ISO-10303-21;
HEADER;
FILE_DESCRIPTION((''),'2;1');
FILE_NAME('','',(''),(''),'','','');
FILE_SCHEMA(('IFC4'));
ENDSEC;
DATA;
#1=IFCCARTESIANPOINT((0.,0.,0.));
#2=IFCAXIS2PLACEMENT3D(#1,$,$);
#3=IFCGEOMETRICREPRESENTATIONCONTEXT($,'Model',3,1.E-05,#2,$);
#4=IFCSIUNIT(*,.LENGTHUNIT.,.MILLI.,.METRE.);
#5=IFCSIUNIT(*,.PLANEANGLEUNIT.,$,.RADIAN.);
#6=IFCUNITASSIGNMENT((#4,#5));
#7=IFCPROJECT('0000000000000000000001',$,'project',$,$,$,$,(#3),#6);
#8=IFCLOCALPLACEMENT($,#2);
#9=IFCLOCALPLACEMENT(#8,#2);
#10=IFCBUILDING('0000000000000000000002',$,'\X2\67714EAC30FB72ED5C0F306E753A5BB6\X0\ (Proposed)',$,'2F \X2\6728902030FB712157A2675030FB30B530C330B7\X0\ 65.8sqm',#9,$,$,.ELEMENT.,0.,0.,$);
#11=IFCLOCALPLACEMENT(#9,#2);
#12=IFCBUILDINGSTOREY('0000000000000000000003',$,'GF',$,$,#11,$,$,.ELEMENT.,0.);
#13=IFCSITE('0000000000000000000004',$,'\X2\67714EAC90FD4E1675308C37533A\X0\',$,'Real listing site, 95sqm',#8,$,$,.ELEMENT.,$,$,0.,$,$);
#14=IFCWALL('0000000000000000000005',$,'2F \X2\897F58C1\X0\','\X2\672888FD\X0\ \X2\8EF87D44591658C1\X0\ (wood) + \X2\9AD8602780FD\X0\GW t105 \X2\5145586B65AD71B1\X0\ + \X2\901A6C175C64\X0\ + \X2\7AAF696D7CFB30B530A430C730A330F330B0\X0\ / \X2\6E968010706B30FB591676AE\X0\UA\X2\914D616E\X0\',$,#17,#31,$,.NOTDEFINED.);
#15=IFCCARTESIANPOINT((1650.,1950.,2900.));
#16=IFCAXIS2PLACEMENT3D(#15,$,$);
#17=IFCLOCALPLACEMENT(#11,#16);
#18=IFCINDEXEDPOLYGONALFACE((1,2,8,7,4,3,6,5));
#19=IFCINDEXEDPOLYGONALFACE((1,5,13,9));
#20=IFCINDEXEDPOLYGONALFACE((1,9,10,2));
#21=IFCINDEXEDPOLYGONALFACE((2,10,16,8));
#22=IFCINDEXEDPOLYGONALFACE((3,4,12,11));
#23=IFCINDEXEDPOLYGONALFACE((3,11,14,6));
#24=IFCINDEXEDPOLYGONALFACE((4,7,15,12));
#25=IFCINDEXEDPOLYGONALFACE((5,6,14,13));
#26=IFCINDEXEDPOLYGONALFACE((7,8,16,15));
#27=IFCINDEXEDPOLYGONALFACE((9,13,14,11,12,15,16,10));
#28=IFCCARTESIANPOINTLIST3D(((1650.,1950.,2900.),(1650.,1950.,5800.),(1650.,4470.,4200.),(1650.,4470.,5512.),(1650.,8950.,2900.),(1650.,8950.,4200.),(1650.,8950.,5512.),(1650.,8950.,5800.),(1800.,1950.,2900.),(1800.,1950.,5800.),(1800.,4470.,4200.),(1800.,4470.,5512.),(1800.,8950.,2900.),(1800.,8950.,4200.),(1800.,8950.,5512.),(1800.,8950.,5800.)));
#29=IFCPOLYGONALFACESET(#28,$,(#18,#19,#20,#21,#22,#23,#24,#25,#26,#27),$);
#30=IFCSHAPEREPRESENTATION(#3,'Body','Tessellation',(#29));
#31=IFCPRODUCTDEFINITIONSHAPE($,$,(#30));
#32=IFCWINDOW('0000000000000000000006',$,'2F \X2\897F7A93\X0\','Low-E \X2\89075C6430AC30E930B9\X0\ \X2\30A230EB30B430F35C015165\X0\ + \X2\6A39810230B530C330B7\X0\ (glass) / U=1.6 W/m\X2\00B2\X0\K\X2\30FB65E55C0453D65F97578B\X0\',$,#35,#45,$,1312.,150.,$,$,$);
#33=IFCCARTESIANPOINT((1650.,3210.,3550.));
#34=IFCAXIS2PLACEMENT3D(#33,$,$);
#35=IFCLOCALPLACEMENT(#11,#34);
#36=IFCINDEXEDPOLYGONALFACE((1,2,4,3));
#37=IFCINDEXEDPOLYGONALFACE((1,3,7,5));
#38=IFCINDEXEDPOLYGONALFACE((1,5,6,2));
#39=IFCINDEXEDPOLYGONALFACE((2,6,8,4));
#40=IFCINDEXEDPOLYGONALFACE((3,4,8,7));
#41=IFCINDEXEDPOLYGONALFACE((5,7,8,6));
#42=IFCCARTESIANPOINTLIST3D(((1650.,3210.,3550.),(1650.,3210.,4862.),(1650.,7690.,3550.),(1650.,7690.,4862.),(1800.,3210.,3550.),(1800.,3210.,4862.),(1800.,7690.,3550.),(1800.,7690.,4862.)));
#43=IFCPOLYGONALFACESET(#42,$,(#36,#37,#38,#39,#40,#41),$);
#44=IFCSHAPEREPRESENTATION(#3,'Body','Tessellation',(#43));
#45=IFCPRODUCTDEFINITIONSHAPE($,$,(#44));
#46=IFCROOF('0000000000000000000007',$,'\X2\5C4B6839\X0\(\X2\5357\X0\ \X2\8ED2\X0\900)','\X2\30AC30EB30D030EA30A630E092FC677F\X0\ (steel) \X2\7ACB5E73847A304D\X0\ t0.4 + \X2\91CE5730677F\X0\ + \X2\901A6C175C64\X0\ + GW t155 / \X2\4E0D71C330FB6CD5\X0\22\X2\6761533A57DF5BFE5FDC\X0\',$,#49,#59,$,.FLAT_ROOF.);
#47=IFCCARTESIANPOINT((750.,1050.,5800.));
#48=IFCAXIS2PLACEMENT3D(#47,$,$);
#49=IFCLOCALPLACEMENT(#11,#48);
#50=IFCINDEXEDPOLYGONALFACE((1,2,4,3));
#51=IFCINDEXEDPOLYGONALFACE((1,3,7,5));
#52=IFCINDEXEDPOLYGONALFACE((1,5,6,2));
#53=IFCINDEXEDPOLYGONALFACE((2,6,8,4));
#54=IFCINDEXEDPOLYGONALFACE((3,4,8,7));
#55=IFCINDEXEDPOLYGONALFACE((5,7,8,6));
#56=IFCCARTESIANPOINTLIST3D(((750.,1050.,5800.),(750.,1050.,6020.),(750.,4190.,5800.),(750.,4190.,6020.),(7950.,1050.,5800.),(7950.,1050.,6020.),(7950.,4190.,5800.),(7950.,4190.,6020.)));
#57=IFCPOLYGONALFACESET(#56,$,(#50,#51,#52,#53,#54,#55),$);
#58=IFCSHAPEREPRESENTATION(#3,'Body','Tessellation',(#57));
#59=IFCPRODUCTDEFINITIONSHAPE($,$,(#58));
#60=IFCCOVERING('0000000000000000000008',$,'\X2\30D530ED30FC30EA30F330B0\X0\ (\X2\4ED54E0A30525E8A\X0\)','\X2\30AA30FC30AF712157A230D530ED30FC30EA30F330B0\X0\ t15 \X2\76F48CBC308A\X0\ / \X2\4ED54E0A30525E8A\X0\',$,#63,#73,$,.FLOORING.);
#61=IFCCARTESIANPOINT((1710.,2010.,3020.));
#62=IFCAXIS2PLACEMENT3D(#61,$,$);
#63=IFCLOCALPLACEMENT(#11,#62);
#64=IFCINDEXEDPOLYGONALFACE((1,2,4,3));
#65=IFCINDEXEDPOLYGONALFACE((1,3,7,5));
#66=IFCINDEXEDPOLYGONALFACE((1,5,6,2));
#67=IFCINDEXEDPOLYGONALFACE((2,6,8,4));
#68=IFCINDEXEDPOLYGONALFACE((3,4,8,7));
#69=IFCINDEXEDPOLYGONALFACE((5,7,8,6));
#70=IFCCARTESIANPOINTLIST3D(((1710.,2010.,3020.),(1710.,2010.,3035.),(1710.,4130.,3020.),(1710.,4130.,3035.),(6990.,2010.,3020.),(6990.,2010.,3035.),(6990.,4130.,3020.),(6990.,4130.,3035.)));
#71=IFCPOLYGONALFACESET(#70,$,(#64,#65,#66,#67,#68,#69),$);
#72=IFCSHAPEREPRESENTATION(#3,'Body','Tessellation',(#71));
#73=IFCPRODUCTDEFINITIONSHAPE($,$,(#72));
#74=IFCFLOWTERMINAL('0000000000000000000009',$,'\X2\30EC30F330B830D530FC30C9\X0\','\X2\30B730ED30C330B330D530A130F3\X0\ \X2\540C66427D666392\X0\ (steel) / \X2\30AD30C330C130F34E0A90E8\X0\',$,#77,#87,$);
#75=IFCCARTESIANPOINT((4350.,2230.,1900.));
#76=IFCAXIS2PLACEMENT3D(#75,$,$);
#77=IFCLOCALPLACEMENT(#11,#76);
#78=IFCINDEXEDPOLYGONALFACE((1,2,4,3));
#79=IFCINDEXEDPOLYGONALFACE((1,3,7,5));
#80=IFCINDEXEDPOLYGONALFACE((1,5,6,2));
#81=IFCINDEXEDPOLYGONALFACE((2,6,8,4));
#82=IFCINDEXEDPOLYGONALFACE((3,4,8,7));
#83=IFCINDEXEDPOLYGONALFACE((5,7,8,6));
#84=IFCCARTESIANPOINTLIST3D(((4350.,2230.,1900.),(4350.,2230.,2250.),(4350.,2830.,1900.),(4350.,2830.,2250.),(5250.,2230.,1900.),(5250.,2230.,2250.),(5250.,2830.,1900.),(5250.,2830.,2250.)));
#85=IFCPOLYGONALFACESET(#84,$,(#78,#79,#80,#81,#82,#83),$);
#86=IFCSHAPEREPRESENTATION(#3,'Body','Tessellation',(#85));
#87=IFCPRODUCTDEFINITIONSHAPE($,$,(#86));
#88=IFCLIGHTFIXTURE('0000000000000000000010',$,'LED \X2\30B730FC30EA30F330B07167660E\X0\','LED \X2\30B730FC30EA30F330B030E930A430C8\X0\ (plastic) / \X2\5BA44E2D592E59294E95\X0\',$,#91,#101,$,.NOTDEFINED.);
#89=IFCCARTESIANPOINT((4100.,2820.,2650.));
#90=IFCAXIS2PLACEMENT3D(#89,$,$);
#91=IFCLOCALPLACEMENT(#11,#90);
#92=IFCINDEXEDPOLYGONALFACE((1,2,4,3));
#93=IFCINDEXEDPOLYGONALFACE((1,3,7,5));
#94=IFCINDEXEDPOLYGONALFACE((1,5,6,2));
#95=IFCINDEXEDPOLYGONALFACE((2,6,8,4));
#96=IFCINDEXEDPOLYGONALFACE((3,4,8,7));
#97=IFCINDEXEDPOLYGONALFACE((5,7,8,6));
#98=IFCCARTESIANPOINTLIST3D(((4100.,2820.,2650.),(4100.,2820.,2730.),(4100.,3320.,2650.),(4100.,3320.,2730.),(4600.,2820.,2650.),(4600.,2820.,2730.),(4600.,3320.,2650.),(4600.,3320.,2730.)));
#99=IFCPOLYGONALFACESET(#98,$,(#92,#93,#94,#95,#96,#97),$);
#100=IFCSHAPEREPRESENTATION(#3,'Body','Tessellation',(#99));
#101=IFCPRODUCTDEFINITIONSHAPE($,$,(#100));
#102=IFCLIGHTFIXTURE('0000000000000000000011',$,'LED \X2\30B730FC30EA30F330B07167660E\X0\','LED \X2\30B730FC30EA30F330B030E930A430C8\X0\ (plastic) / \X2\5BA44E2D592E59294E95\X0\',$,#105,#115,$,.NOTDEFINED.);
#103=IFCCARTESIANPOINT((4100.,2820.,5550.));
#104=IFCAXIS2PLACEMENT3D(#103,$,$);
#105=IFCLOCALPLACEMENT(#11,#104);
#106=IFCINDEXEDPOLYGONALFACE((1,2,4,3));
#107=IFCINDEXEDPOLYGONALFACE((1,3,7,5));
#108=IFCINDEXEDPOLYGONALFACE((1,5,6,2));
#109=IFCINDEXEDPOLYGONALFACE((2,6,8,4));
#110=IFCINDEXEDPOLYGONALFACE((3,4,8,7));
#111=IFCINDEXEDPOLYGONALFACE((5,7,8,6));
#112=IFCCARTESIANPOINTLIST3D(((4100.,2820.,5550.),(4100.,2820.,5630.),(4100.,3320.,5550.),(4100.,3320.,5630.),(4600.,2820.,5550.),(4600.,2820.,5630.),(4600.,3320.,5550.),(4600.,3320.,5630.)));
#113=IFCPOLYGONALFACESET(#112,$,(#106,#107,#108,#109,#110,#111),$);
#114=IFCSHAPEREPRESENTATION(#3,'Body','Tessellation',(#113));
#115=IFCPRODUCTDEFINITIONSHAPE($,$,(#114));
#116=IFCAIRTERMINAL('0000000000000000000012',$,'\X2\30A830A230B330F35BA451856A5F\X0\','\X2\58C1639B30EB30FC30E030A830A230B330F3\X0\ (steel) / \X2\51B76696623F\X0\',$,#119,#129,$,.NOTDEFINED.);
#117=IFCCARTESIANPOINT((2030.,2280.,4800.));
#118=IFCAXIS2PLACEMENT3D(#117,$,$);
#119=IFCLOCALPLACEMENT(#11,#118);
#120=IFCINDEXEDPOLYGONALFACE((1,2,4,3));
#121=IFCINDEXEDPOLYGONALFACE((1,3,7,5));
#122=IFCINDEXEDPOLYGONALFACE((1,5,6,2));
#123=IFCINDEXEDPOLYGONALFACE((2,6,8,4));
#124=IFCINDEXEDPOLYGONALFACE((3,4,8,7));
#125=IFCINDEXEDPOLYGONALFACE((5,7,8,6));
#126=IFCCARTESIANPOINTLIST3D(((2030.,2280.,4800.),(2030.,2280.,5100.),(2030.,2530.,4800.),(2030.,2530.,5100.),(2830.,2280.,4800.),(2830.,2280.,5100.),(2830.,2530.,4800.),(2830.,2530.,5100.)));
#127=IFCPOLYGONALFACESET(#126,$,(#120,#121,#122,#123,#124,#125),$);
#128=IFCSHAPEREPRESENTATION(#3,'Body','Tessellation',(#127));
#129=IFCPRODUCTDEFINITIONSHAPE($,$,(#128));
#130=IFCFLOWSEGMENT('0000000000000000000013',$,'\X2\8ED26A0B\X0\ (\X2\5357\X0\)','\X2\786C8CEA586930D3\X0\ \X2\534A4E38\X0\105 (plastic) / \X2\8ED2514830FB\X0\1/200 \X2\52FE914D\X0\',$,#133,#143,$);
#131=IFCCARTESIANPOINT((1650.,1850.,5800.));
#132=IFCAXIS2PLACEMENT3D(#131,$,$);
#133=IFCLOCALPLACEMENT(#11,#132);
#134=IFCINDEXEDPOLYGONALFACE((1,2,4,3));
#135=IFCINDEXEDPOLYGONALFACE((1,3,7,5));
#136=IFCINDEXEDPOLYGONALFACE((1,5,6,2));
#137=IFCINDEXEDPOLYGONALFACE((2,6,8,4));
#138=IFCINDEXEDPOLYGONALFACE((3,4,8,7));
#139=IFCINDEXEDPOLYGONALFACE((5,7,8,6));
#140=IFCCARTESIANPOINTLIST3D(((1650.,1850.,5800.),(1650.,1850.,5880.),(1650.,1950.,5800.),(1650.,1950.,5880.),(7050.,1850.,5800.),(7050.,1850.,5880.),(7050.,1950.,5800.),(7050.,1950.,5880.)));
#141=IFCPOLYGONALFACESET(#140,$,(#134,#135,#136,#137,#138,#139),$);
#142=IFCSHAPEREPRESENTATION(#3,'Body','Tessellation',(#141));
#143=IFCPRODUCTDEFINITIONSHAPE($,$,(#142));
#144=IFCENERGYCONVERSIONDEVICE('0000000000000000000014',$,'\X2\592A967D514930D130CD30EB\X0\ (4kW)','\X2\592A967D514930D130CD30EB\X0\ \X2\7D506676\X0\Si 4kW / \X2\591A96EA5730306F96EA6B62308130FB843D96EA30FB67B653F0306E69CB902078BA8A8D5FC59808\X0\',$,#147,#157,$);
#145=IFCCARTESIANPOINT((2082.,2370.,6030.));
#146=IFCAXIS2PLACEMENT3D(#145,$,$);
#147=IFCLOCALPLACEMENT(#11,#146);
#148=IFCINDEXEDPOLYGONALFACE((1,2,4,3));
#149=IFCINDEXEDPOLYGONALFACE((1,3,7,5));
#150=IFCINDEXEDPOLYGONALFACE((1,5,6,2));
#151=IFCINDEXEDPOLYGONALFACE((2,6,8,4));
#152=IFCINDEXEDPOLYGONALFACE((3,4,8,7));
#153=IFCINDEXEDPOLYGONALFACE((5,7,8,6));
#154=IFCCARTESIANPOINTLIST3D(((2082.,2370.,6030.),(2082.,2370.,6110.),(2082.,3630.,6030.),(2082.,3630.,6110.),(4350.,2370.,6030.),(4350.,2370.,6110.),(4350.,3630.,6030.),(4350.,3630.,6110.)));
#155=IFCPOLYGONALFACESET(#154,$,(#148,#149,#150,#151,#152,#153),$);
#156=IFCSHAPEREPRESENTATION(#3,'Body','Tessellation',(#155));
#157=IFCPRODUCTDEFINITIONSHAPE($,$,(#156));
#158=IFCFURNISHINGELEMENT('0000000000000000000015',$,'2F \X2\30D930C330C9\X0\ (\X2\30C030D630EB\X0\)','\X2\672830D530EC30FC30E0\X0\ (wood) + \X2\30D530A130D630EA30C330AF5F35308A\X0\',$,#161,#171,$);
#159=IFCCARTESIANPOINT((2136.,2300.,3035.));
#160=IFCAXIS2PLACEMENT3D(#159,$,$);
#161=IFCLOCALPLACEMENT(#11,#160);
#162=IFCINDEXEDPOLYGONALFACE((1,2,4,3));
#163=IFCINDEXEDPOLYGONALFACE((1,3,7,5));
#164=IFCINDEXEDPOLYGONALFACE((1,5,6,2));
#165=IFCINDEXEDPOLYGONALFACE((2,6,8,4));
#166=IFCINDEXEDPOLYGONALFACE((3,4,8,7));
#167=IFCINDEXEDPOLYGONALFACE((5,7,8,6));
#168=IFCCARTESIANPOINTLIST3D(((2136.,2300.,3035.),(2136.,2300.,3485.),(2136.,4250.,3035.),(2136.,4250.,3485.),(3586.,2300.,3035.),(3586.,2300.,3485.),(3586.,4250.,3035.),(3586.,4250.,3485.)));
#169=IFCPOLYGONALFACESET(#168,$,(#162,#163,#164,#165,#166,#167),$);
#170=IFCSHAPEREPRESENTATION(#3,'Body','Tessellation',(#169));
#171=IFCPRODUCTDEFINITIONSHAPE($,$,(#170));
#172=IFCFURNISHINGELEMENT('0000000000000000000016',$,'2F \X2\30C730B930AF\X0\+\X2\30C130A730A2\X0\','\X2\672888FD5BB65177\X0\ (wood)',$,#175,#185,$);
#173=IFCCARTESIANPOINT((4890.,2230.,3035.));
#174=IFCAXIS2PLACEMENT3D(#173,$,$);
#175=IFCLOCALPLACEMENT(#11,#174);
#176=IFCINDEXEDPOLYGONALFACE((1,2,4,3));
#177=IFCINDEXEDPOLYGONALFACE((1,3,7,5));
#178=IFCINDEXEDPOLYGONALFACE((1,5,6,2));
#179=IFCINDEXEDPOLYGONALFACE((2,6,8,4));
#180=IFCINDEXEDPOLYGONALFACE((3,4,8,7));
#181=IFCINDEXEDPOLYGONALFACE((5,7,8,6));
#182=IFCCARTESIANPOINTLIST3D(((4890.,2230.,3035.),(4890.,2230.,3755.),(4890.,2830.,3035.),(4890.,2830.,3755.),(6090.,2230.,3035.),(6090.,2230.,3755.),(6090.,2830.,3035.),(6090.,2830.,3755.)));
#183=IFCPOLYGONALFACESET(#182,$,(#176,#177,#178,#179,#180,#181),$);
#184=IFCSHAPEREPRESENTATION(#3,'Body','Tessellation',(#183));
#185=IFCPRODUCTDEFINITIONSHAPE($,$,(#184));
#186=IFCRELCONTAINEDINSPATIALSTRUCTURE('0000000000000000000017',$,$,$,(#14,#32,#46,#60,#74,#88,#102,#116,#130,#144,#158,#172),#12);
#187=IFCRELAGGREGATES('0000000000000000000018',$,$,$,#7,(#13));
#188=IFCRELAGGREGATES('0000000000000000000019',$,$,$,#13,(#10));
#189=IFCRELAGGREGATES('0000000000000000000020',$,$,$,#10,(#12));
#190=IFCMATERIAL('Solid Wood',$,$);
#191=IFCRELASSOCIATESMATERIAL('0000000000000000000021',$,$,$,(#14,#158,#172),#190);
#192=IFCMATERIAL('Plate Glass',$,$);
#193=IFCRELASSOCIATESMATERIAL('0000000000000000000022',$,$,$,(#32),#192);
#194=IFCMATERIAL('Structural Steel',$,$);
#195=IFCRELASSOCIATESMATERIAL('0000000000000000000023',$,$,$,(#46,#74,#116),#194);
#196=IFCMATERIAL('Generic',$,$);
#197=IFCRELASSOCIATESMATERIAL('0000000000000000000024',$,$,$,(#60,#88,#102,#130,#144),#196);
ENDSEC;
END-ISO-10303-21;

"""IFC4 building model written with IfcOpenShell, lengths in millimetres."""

from ifc_helpers import new_model, si_unit, frame, frame_2d, origin, place, context, project, spatial, rectangle, extrude, material, element, fill, save


model = new_model("IFC4")

# Units and contexts
model_context = context("Model", 3, precision=1e-05, world=origin())
ifc_project = project(units=[si_unit("LENGTHUNIT", "METRE", prefix="MILLI"), si_unit("PLANEANGLEUNIT", "RADIAN")], contexts=[model_context])

# Site, building, storey
site_placement = place(None, origin())
site = spatial("IfcSite", under=ifc_project, at=site_placement, Name="東京都世田谷区", ObjectType="Real listing site, 95sqm", CompositionType="ELEMENT", RefElevation=0.0)
building_placement = place(site_placement, origin())
building = spatial("IfcBuilding", under=site, at=building_placement, Name="東京・狭小の町家 (Proposed)", ObjectType="2F 木造・無垢材・サッシ 65.8sqm", CompositionType="ELEMENT", ElevationOfRefHeight=0.0, ElevationOfTerrain=0.0)
storey_placement = place(building_placement, origin())
storey = spatial("IfcBuildingStorey", under=building, at=storey_placement, Name="GF", CompositionType="ELEMENT", Elevation=0.0)

# Shared definitions
ifc_material_1 = material(Name="Solid Wood")

# Wall, opening, window
ifc_material_2 = material(Name="Plate Glass")
wall_1_placement = place(storey_placement, frame((1650.0, 1950.0, 2900.0)))
wall_1 = element("IfcWall", 1, at=wall_1_placement, inside=storey, material=ifc_material_1, Name="2F 西壁", Description="木製 軸組外壁 (wood) + 高性能GW t105 充填断熱 + 通気層 + 窯業系サイディング / 準耐火・外皮UA配慮", PredefinedType="NOTDEFINED", context=model_context, shape_type="SweptSolid", body=[
    extrude(rectangle(XDim=150.0, YDim=7000.0, at=frame_2d((75.0, 3500.0))), frame((1650.0, 1950.0, 2900.0)), (0.0, 0.0, 1.0), 2900.0),
])
opening_1_placement = place(storey_placement, frame((1650.0, 3210.0, 3550.0)))
opening_1 = element("IfcOpeningElement", 2, at=opening_1_placement, cuts=wall_1, PredefinedType="NOTDEFINED", context=model_context, shape_type="SweptSolid", body=[
    extrude(rectangle(XDim=150.0, YDim=4480.0, at=frame_2d((75.0, 2240.0))), frame((1650.0, 3210.0, 3550.0)), (0.0, 0.0, 1.0), 1312.0),
])
window_1_placement = place(storey_placement, frame((1650.0, 3210.0, 3550.0)))
window_1 = element("IfcWindow", 3, at=window_1_placement, inside=storey, material=ifc_material_2, Name="2F 西窓", Description="Low-E 複層ガラス アルゴン封入 + 樹脂サッシ (glass) / U=1.6 W/m²K・日射取得型", OverallHeight=1312.0, OverallWidth=150.0, context=model_context, shape_type="SweptSolid", body=[
    extrude(rectangle(XDim=150.0, YDim=4480.0, at=frame_2d((75.0, 2240.0))), frame((1650.0, 3210.0, 3550.0)), (0.0, 0.0, 1.0), 1312.0),
])
fill(opening_1, window_1)

# Roof
ifc_material_3 = material(Name="Structural Steel")
for number, where, name in (
    (4, (750.0, 1050.0, 5800.0), "屋根(南 軒900)"),
):
    element("IfcRoof", number, at=place(storey_placement, frame(where)), inside=storey, material=ifc_material_3, Name=name, Description="ガルバリウム鋼板 (steel) 立平葺き t0.4 + 野地板 + 通気層 + GW t155 / 不燃・法22条区域対応", PredefinedType="FLAT_ROOF", context=model_context, shape_type="SweptSolid", body=[
        extrude(rectangle(XDim=7200.0, YDim=3140.0, at=frame_2d((3600.0, 1570.0))), frame((750.0, 1050.0, 5800.0)), (0.0, 0.0, 1.0), 220.0),
    ])

# Covering
ifc_material_4 = material(Name="Generic")
covering_placement = place(storey_placement, frame((1710.0, 2010.0, 3020.0)))
element("IfcCovering", 5, at=covering_placement, inside=storey, material=ifc_material_4, Name="フローリング (仕上げ床)", Description="オーク無垢フローリング t15 直貼り / 仕上げ床", PredefinedType="FLOORING", context=model_context, shape_type="SweptSolid", body=[
    extrude(rectangle(XDim=5280.0, YDim=2120.0, at=frame_2d((2640.0, 1060.0))), frame((1710.0, 2010.0, 3020.0)), (0.0, 0.0, 1.0), 15.0),
])

# Flow terminal
flow_terminal_placement = place(storey_placement, frame((4350.0, 2230.0, 1900.0)))
element("IfcFlowTerminal", 6, at=flow_terminal_placement, inside=storey, material=ifc_material_3, Name="レンジフード", Description="シロッコファン 同時給排 (steel) / キッチン上部", context=model_context, shape_type="SweptSolid", body=[
    extrude(rectangle(XDim=900.0, YDim=600.0, at=frame_2d((450.0, 300.0))), frame((4350.0, 2230.0, 1900.0)), (0.0, 0.0, 1.0), 350.0),
])

# Light fixtures
light_fixture_1_placement = place(storey_placement, frame((4100.0, 2820.0, 2650.0)))
element("IfcLightFixture", 7, at=light_fixture_1_placement, inside=storey, material=ifc_material_4, Name="LED シーリング照明", Description="LED シーリングライト (plastic) / 室中央天井", PredefinedType="NOTDEFINED", context=model_context, shape_type="SweptSolid", body=[
    extrude(rectangle(XDim=500.0, YDim=500.0, at=frame_2d((250.0, 250.0))), frame((4100.0, 2820.0, 2650.0)), (0.0, 0.0, 1.0), 80.0),
])
light_fixture_2_placement = place(storey_placement, frame((4100.0, 2820.0, 5550.0)))
element("IfcLightFixture", 8, at=light_fixture_2_placement, inside=storey, material=ifc_material_4, Name="LED シーリング照明", Description="LED シーリングライト (plastic) / 室中央天井", PredefinedType="NOTDEFINED", context=model_context, shape_type="SweptSolid", body=[
    extrude(rectangle(XDim=500.0, YDim=500.0, at=frame_2d((250.0, 250.0))), frame((4100.0, 2820.0, 5550.0)), (0.0, 0.0, 1.0), 80.0),
])

# Air terminal
air_terminal_placement = place(storey_placement, frame((2030.0, 2280.0, 4800.0)))
element("IfcAirTerminal", 9, at=air_terminal_placement, inside=storey, material=ifc_material_3, Name="エアコン室内機", Description="壁掛ルームエアコン (steel) / 冷暖房", PredefinedType="NOTDEFINED", context=model_context, shape_type="SweptSolid", body=[
    extrude(rectangle(XDim=800.0, YDim=250.0, at=frame_2d((400.0, 125.0))), frame((2030.0, 2280.0, 4800.0)), (0.0, 0.0, 1.0), 300.0),
])

# Flow segment
flow_segment_placement = place(storey_placement, frame((1650.0, 1850.0, 5800.0)))
element("IfcFlowSegment", 10, at=flow_segment_placement, inside=storey, material=ifc_material_4, Name="軒樋 (南)", Description="硬質塩ビ 半丸105 (plastic) / 軒先・1/200 勾配", context=model_context, shape_type="SweptSolid", body=[
    extrude(rectangle(XDim=5400.0, YDim=100.0, at=frame_2d((2700.0, 50.0))), frame((1650.0, 1850.0, 5800.0)), (0.0, 0.0, 1.0), 80.0),
])

# Energy conversion device
energy_conversion_device_placement = place(storey_placement, frame((2082.0, 2370.0, 6030.0)))
element("IfcEnergyConversionDevice", 11, at=energy_conversion_device_placement, inside=storey, material=ifc_material_4, Name="太陽光パネル (4kW)", Description="太陽光パネル 結晶Si 4kW / 多雪地は雪止め・落雪・架台の構造確認必須", context=model_context, shape_type="SweptSolid", body=[
    extrude(rectangle(XDim=2268.0, YDim=1260.0, at=frame_2d((1134.0, 630.0))), frame((2082.0, 2370.0, 6030.0)), (0.0, 0.0, 1.0), 80.0),
])

# Furnishing elements
furnishing_1_placement = place(storey_placement, frame((2136.0, 2300.0, 3035.0)))
element("IfcFurnishingElement", 12, at=furnishing_1_placement, inside=storey, material=ifc_material_1, Name="2F ベッド (ダブル)", Description="木フレーム (wood) + ファブリック張り", context=model_context, shape_type="SweptSolid", body=[
    extrude(rectangle(XDim=1450.0, YDim=1950.0, at=frame_2d((725.0, 975.0))), frame((2136.0, 2300.0, 3035.0)), (0.0, 0.0, 1.0), 450.0),
])
furnishing_2_placement = place(storey_placement, frame((4890.0, 2230.0, 3035.0)))
element("IfcFurnishingElement", 13, at=furnishing_2_placement, inside=storey, material=ifc_material_1, Name="2F デスク+チェア", Description="木製家具 (wood)", context=model_context, shape_type="SweptSolid", body=[
    extrude(rectangle(XDim=1200.0, YDim=600.0, at=frame_2d((600.0, 300.0))), frame((4890.0, 2230.0, 3035.0)), (0.0, 0.0, 1.0), 720.0),
])

save(model, "model.ifc")
